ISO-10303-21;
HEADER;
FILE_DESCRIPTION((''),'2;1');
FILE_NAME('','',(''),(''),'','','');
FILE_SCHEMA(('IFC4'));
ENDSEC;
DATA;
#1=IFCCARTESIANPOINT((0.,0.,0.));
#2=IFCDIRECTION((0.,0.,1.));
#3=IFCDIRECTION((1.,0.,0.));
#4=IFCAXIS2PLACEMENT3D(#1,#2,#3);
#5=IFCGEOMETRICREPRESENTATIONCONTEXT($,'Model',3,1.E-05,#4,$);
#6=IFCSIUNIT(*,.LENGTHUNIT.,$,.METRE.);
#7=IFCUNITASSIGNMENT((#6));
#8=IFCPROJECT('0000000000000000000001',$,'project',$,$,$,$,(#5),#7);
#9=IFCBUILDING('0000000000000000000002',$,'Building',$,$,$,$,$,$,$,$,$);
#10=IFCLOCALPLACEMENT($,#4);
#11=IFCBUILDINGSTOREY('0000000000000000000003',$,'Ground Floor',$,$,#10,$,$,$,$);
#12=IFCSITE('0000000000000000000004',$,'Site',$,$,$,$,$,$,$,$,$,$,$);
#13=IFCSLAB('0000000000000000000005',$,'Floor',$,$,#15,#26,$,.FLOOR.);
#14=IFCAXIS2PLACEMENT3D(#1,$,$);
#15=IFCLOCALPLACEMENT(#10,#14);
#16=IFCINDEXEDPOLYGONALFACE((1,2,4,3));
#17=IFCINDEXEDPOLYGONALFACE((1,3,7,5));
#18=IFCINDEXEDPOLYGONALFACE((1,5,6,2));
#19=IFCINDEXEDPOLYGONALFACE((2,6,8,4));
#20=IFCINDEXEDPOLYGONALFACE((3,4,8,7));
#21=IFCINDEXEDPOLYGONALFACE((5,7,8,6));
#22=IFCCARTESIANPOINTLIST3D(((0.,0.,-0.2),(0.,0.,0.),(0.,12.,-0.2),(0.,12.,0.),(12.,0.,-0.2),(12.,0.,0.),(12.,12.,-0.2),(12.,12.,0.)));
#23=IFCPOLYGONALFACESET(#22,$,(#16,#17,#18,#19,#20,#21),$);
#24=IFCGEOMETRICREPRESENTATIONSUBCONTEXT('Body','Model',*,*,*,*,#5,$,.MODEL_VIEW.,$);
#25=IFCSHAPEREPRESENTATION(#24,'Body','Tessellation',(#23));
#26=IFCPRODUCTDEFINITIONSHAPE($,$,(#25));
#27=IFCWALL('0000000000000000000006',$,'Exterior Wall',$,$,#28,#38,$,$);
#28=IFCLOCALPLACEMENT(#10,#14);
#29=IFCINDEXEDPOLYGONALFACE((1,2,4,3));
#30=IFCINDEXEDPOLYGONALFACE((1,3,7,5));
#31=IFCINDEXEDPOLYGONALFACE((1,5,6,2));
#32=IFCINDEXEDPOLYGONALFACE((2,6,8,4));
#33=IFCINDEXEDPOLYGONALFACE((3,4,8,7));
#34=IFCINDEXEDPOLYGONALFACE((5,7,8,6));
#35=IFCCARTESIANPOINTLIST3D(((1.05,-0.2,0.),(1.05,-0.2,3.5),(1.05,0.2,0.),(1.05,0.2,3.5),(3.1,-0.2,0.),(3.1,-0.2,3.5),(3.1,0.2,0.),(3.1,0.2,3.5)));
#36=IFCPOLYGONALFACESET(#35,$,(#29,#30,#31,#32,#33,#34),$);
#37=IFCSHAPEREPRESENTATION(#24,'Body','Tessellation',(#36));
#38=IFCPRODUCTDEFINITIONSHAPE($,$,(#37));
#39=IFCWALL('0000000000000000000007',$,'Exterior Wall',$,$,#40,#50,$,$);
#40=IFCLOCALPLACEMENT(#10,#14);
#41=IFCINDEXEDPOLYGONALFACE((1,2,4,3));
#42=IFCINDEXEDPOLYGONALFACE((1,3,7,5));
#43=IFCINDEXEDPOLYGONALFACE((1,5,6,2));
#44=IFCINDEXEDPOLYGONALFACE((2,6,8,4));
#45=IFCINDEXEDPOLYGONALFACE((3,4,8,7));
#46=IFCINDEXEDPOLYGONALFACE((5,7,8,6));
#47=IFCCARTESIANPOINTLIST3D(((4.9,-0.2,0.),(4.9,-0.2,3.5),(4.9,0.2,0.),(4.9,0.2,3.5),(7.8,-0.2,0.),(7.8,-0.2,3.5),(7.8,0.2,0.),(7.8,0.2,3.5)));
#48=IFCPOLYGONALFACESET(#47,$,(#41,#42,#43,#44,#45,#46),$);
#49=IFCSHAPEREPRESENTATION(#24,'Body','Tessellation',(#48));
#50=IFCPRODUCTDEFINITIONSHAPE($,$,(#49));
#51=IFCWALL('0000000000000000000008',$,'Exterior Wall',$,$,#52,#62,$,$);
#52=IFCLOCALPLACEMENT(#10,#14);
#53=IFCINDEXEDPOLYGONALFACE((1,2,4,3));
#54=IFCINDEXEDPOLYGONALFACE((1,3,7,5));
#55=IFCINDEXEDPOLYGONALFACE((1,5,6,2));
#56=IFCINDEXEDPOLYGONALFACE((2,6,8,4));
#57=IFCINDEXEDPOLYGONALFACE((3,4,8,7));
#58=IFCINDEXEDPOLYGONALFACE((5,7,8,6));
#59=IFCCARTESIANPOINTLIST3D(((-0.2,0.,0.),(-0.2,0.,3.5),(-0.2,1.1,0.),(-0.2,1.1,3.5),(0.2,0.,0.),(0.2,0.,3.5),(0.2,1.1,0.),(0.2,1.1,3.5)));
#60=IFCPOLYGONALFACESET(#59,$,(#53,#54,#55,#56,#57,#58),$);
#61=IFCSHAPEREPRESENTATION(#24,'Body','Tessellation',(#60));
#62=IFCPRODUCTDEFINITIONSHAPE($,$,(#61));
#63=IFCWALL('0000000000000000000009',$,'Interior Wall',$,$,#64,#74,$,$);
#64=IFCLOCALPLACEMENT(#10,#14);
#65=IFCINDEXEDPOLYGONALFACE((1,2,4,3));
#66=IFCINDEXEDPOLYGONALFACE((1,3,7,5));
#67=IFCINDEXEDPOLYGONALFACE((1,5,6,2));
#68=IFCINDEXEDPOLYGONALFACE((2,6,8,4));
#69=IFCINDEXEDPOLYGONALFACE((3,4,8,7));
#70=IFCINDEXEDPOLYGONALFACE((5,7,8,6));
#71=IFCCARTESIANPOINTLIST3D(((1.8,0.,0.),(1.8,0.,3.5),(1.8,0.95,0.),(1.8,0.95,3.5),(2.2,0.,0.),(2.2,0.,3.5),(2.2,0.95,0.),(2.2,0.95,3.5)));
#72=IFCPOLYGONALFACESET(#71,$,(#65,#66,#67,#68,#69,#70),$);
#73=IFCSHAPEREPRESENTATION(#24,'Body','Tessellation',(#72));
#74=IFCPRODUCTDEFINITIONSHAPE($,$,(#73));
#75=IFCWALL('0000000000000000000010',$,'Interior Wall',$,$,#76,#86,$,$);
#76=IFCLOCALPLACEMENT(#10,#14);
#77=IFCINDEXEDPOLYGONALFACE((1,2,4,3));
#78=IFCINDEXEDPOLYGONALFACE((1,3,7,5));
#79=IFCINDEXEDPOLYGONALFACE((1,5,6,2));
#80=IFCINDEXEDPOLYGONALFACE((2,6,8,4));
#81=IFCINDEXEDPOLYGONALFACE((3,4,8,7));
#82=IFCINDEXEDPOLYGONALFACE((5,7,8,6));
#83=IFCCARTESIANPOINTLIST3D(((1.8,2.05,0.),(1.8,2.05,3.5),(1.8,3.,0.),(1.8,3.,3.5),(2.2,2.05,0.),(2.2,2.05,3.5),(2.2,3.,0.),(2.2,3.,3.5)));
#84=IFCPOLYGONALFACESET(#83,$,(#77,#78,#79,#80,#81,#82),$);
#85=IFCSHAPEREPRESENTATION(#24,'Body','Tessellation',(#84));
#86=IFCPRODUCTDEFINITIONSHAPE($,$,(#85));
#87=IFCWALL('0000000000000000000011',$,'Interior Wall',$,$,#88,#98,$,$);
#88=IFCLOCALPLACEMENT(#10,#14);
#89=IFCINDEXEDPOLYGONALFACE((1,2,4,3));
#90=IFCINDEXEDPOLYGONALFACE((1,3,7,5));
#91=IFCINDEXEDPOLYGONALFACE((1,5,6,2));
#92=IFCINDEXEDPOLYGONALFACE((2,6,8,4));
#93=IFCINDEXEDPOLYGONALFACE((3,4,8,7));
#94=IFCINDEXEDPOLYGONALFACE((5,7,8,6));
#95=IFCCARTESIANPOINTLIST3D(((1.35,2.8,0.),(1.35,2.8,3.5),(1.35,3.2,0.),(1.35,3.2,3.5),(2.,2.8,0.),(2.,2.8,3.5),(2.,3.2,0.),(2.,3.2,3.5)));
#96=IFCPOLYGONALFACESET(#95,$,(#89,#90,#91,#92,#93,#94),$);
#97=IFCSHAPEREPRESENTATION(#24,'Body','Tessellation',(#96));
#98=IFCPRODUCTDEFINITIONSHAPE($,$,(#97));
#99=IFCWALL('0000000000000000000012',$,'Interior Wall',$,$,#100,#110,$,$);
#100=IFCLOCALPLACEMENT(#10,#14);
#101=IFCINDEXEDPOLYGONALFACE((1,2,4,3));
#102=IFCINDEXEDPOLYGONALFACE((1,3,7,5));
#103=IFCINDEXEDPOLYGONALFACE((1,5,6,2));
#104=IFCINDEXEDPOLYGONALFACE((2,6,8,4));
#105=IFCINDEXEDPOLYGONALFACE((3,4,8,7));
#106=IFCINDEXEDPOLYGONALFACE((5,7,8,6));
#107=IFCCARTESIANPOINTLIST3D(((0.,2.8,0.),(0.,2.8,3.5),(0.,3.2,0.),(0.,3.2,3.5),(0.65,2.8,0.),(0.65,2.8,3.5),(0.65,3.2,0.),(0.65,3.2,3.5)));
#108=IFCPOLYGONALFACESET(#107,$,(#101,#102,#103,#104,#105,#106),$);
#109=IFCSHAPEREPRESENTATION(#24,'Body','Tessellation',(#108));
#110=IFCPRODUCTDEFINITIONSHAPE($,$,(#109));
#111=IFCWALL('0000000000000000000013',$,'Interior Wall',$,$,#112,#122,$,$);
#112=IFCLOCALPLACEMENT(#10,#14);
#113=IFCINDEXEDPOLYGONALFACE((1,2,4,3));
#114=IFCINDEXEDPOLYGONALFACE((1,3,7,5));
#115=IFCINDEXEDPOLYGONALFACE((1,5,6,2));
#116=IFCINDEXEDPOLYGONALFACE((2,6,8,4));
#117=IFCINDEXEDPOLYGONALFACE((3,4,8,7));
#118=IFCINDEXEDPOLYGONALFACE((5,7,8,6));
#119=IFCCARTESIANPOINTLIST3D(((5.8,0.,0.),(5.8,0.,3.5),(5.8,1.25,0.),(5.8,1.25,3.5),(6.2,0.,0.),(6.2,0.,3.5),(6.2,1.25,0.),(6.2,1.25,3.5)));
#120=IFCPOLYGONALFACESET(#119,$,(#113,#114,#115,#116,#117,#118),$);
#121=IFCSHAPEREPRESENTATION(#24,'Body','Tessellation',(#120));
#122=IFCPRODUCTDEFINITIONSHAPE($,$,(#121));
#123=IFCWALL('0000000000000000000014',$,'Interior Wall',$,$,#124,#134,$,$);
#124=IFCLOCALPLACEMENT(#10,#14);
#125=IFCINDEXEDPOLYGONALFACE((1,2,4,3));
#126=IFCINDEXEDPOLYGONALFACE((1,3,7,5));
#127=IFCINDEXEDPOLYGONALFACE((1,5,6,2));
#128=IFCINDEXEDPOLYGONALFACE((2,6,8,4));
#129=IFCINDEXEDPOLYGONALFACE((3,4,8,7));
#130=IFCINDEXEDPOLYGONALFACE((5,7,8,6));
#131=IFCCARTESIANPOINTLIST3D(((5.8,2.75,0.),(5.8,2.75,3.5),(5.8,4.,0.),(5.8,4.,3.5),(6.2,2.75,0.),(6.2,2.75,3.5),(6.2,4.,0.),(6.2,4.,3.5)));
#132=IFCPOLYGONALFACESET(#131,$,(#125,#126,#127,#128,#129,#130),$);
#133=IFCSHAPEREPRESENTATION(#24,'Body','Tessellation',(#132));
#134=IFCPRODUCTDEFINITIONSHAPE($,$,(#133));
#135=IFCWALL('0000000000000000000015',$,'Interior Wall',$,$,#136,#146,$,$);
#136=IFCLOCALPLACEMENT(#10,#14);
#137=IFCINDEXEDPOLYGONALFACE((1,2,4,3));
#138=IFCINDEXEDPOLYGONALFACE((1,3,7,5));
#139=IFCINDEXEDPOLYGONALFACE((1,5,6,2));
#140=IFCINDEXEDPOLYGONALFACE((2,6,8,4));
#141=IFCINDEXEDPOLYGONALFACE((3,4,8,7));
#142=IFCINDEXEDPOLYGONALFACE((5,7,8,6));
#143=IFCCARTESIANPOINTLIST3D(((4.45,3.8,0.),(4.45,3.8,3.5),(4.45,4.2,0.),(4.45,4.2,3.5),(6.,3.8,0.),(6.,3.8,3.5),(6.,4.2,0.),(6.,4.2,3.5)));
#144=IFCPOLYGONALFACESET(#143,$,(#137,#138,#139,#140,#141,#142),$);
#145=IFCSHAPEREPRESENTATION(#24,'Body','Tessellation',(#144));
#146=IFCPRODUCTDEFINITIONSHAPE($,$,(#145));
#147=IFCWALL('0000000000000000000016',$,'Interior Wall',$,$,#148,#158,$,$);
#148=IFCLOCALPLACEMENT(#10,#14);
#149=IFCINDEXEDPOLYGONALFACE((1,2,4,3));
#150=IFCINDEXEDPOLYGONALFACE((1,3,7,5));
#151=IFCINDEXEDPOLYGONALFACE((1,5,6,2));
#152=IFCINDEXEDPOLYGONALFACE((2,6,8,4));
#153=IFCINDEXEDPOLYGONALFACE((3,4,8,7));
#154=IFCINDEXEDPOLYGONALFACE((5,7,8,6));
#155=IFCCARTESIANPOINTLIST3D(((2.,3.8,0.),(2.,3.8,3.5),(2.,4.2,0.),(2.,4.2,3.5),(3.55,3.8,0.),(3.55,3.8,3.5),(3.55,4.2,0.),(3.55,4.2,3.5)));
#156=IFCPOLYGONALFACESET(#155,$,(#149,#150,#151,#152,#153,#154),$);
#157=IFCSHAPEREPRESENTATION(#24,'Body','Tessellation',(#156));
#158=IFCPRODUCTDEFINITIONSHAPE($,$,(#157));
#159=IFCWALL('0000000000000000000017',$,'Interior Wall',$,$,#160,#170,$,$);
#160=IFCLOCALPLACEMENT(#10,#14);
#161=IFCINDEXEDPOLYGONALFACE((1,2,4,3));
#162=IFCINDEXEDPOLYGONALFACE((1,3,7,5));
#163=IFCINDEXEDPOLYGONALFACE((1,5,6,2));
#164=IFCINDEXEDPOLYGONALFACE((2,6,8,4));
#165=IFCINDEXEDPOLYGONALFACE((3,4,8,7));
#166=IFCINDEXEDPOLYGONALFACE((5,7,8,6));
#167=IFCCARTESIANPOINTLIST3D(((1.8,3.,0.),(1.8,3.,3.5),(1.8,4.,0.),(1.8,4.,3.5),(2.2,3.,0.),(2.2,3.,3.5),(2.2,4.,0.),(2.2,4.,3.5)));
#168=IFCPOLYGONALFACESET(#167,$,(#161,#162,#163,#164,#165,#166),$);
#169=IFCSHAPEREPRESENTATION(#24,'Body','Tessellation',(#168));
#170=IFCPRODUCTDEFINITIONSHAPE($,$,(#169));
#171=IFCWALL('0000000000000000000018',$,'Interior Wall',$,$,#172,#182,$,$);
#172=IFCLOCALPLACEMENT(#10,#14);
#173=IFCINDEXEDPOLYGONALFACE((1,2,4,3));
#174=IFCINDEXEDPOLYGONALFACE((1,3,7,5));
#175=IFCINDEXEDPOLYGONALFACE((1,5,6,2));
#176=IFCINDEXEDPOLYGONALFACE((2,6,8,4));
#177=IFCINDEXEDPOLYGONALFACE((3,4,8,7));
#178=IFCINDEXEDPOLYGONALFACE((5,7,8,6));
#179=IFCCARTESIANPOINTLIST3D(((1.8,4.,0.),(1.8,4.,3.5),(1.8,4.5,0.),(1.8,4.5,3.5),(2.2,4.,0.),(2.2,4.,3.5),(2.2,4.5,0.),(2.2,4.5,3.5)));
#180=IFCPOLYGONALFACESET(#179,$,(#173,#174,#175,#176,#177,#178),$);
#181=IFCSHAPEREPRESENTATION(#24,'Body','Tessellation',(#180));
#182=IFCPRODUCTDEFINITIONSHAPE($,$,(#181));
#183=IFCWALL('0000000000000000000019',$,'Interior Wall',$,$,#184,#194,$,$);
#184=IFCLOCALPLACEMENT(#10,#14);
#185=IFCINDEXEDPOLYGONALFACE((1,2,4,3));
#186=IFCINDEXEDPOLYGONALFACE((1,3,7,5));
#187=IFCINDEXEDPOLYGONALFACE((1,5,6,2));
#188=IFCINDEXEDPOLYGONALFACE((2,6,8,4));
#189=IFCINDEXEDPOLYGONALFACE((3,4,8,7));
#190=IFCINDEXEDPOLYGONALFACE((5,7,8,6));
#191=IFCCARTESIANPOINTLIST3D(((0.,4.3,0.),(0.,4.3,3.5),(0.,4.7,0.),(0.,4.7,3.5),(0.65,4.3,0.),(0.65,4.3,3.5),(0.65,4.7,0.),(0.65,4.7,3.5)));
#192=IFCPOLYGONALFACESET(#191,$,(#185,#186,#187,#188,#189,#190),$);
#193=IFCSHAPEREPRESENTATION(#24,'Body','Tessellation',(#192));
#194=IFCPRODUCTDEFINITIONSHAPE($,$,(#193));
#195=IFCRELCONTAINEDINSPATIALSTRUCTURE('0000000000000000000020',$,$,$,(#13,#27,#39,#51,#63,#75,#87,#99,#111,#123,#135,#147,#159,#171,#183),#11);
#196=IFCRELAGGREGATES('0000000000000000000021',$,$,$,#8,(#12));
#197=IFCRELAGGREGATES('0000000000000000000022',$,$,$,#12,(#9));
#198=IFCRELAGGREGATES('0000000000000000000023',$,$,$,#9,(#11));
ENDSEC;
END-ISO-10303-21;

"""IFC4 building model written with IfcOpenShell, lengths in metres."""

from ifc_helpers import new_model, si_unit, frame, origin_with_axes, place, context, subcontext, project, spatial, indexed_curve, outline, extrude, element, save


model = new_model("IFC4")

# Units and contexts
model_context = context("Model", 3, precision=1e-05, world=origin_with_axes())
body_context = subcontext(model_context, "Body", "Model", "MODEL_VIEW")
ifc_project = project(units=[si_unit("LENGTHUNIT", "METRE")], contexts=[model_context])

# Site, building, storey
site = spatial("IfcSite", under=ifc_project, Name="Site")
building = spatial("IfcBuilding", under=site, Name="Building")
storey_placement = place(None, origin_with_axes())
storey = spatial("IfcBuildingStorey", under=building, at=storey_placement, Name="Ground Floor")

# Slab
slab_placement = place(storey_placement, frame((0.0, 0.0, -0.2), z_axis=(0.0, 0.0, 1.0), x_axis=(1.0, 0.0, 0.0)))
element("IfcSlab", 1, at=slab_placement, inside=storey, Name="Floor", PredefinedType="FLOOR", context=body_context, shape_type="SweptSolid", body=[
    extrude(outline(indexed_curve([(0.0, 0.0), (12.0, 0.0), (12.0, 12.0), (0.0, 12.0)])), None, (0.0, 0.0, 1.0), 0.2),
])

# Walls
wall_1_placement = place(storey_placement, frame((1.05, 0.0, 0.0), z_axis=(0.0, 0.0, 1.0), x_axis=(1.0, 0.0, 0.0)))
element("IfcWall", 2, at=wall_1_placement, inside=storey, Name="Exterior Wall", context=body_context, shape_type="SweptSolid", body=[
    extrude(outline(indexed_curve([(0.0, 0.0), (0.0, 0.4), (2.05, 0.4), (2.05, 0.0), (0.0, 0.0)], self_intersect=False)), frame((0.0, -0.2, 0.0), z_axis=(0.0, 0.0, 1.0), x_axis=(1.0, 0.0, 0.0)), (0.0, 0.0, 1.0), 3.5),
])
wall_2_placement = place(storey_placement, frame((4.9, 0.0, 0.0), z_axis=(0.0, 0.0, 1.0), x_axis=(1.0, 0.0, 0.0)))
element("IfcWall", 3, at=wall_2_placement, inside=storey, Name="Exterior Wall", context=body_context, shape_type="SweptSolid", body=[
    extrude(outline(indexed_curve([(0.0, 0.0), (0.0, 0.4), (2.9, 0.4), (2.9, 0.0), (0.0, 0.0)], self_intersect=False)), frame((0.0, -0.2, 0.0), z_axis=(0.0, 0.0, 1.0), x_axis=(1.0, 0.0, 0.0)), (0.0, 0.0, 1.0), 3.5),
])
wall_3_placement = place(storey_placement, frame((0.0, 1.1, 0.0), z_axis=(0.0, 0.0, 1.0), x_axis=(0.0, -1.0, 0.0)))
element("IfcWall", 4, at=wall_3_placement, inside=storey, Name="Exterior Wall", context=body_context, shape_type="SweptSolid", body=[
    extrude(outline(indexed_curve([(0.0, 0.0), (0.0, 0.4), (1.1, 0.4), (1.1, 0.0), (0.0, 0.0)], self_intersect=False)), frame((0.0, -0.2, 0.0), z_axis=(0.0, 0.0, 1.0), x_axis=(1.0, 0.0, 0.0)), (0.0, 0.0, 1.0), 3.5),
])
wall_4_placement = place(storey_placement, frame((2.0, 0.0, 0.0), z_axis=(0.0, 0.0, 1.0), x_axis=(0.0, 1.0, 0.0)))
element("IfcWall", 5, at=wall_4_placement, inside=storey, Name="Interior Wall", context=body_context, shape_type="SweptSolid", body=[
    extrude(outline(indexed_curve([(0.0, 0.0), (0.0, 0.4), (0.95, 0.4), (0.95, 0.0), (0.0, 0.0)], self_intersect=False)), frame((0.0, -0.2, 0.0), z_axis=(0.0, 0.0, 1.0), x_axis=(1.0, 0.0, 0.0)), (0.0, 0.0, 1.0), 3.5),
])
wall_5_placement = place(storey_placement, frame((2.0, 2.05, 0.0), z_axis=(0.0, 0.0, 1.0), x_axis=(0.0, 1.0, 0.0)))
element("IfcWall", 6, at=wall_5_placement, inside=storey, Name="Interior Wall", context=body_context, shape_type="SweptSolid", body=[
    extrude(outline(indexed_curve([(0.0, 0.0), (0.0, 0.4), (0.95, 0.4), (0.95, 0.0), (0.0, 0.0)], self_intersect=False)), frame((0.0, -0.2, 0.0), z_axis=(0.0, 0.0, 1.0), x_axis=(1.0, 0.0, 0.0)), (0.0, 0.0, 1.0), 3.5),
])
for number, where, z_axis, x_axis, name in (
    (7, (2.0, 3.0, 0.0), (0.0, 0.0, 1.0), (-1.0, 0.0, 0.0), "Interior Wall"),
    (8, (0.65, 3.0, 0.0), (0.0, 0.0, 1.0), (-1.0, 0.0, 0.0), "Interior Wall"),
):
    element("IfcWall", number, at=place(storey_placement, frame(where, z_axis=z_axis, x_axis=x_axis)), inside=storey, Name=name, context=body_context, shape_type="SweptSolid", body=[
        extrude(outline(indexed_curve([(0.0, 0.0), (0.0, 0.4), (0.65, 0.4), (0.65, 0.0), (0.0, 0.0)], self_intersect=False)), frame((0.0, -0.2, 0.0), z_axis=(0.0, 0.0, 1.0), x_axis=(1.0, 0.0, 0.0)), (0.0, 0.0, 1.0), 3.5),
    ])
for number, where, z_axis, x_axis, name in (
    (9, (6.0, 0.0, 0.0), (0.0, 0.0, 1.0), (0.0, 1.0, 0.0), "Interior Wall"),
    (10, (6.0, 2.75, 0.0), (0.0, 0.0, 1.0), (0.0, 1.0, 0.0), "Interior Wall"),
):
    element("IfcWall", number, at=place(storey_placement, frame(where, z_axis=z_axis, x_axis=x_axis)), inside=storey, Name=name, context=body_context, shape_type="SweptSolid", body=[
        extrude(outline(indexed_curve([(0.0, 0.0), (0.0, 0.4), (1.25, 0.4), (1.25, 0.0), (0.0, 0.0)], self_intersect=False)), frame((0.0, -0.2, 0.0), z_axis=(0.0, 0.0, 1.0), x_axis=(1.0, 0.0, 0.0)), (0.0, 0.0, 1.0), 3.5),
    ])
for number, where, z_axis, x_axis, name in (
    (11, (6.0, 4.0, 0.0), (0.0, 0.0, 1.0), (-1.0, 0.0, 0.0), "Interior Wall"),
    (12, (3.55, 4.0, 0.0), (0.0, 0.0, 1.0), (-1.0, 0.0, 0.0), "Interior Wall"),
):
    element("IfcWall", number, at=place(storey_placement, frame(where, z_axis=z_axis, x_axis=x_axis)), inside=storey, Name=name, context=body_context, shape_type="SweptSolid", body=[
        extrude(outline(indexed_curve([(0.0, 0.0), (0.0, 0.4), (1.55, 0.4), (1.55, 0.0), (0.0, 0.0)], self_intersect=False)), frame((0.0, -0.2, 0.0), z_axis=(0.0, 0.0, 1.0), x_axis=(1.0, 0.0, 0.0)), (0.0, 0.0, 1.0), 3.5),
    ])
wall_6_placement = place(storey_placement, frame((2.0, 4.0, 0.0), z_axis=(0.0, 0.0, 1.0), x_axis=(0.0, -1.0, 0.0)))
element("IfcWall", 13, at=wall_6_placement, inside=storey, Name="Interior Wall", context=body_context, shape_type="SweptSolid", body=[
    extrude(outline(indexed_curve([(0.0, 0.0), (0.0, 0.4), (1.0, 0.4), (1.0, 0.0), (0.0, 0.0)], self_intersect=False)), frame((0.0, -0.2, 0.0), z_axis=(0.0, 0.0, 1.0), x_axis=(1.0, 0.0, 0.0)), (0.0, 0.0, 1.0), 3.5),
])
wall_7_placement = place(storey_placement, frame((2.0, 4.0, 0.0), z_axis=(0.0, 0.0, 1.0), x_axis=(0.0, 1.0, 0.0)))
element("IfcWall", 14, at=wall_7_placement, inside=storey, Name="Interior Wall", context=body_context, shape_type="SweptSolid", body=[
    extrude(outline(indexed_curve([(0.0, 0.0), (0.0, 0.4), (0.5, 0.4), (0.5, 0.0), (0.0, 0.0)], self_intersect=False)), frame((0.0, -0.2, 0.0), z_axis=(0.0, 0.0, 1.0), x_axis=(1.0, 0.0, 0.0)), (0.0, 0.0, 1.0), 3.5),
])
wall_8_placement = place(storey_placement, frame((0.65, 4.5, 0.0), z_axis=(0.0, 0.0, 1.0), x_axis=(-1.0, 0.0, 0.0)))
element("IfcWall", 15, at=wall_8_placement, inside=storey, Name="Interior Wall", context=body_context, shape_type="SweptSolid", body=[
    extrude(outline(indexed_curve([(0.0, 0.0), (0.0, 0.4), (0.65, 0.4), (0.65, 0.0), (0.0, 0.0)], self_intersect=False)), frame((0.0, -0.2, 0.0), z_axis=(0.0, 0.0, 1.0), x_axis=(1.0, 0.0, 0.0)), (0.0, 0.0, 1.0), 3.5),
])

save(model, "model.ifc")
